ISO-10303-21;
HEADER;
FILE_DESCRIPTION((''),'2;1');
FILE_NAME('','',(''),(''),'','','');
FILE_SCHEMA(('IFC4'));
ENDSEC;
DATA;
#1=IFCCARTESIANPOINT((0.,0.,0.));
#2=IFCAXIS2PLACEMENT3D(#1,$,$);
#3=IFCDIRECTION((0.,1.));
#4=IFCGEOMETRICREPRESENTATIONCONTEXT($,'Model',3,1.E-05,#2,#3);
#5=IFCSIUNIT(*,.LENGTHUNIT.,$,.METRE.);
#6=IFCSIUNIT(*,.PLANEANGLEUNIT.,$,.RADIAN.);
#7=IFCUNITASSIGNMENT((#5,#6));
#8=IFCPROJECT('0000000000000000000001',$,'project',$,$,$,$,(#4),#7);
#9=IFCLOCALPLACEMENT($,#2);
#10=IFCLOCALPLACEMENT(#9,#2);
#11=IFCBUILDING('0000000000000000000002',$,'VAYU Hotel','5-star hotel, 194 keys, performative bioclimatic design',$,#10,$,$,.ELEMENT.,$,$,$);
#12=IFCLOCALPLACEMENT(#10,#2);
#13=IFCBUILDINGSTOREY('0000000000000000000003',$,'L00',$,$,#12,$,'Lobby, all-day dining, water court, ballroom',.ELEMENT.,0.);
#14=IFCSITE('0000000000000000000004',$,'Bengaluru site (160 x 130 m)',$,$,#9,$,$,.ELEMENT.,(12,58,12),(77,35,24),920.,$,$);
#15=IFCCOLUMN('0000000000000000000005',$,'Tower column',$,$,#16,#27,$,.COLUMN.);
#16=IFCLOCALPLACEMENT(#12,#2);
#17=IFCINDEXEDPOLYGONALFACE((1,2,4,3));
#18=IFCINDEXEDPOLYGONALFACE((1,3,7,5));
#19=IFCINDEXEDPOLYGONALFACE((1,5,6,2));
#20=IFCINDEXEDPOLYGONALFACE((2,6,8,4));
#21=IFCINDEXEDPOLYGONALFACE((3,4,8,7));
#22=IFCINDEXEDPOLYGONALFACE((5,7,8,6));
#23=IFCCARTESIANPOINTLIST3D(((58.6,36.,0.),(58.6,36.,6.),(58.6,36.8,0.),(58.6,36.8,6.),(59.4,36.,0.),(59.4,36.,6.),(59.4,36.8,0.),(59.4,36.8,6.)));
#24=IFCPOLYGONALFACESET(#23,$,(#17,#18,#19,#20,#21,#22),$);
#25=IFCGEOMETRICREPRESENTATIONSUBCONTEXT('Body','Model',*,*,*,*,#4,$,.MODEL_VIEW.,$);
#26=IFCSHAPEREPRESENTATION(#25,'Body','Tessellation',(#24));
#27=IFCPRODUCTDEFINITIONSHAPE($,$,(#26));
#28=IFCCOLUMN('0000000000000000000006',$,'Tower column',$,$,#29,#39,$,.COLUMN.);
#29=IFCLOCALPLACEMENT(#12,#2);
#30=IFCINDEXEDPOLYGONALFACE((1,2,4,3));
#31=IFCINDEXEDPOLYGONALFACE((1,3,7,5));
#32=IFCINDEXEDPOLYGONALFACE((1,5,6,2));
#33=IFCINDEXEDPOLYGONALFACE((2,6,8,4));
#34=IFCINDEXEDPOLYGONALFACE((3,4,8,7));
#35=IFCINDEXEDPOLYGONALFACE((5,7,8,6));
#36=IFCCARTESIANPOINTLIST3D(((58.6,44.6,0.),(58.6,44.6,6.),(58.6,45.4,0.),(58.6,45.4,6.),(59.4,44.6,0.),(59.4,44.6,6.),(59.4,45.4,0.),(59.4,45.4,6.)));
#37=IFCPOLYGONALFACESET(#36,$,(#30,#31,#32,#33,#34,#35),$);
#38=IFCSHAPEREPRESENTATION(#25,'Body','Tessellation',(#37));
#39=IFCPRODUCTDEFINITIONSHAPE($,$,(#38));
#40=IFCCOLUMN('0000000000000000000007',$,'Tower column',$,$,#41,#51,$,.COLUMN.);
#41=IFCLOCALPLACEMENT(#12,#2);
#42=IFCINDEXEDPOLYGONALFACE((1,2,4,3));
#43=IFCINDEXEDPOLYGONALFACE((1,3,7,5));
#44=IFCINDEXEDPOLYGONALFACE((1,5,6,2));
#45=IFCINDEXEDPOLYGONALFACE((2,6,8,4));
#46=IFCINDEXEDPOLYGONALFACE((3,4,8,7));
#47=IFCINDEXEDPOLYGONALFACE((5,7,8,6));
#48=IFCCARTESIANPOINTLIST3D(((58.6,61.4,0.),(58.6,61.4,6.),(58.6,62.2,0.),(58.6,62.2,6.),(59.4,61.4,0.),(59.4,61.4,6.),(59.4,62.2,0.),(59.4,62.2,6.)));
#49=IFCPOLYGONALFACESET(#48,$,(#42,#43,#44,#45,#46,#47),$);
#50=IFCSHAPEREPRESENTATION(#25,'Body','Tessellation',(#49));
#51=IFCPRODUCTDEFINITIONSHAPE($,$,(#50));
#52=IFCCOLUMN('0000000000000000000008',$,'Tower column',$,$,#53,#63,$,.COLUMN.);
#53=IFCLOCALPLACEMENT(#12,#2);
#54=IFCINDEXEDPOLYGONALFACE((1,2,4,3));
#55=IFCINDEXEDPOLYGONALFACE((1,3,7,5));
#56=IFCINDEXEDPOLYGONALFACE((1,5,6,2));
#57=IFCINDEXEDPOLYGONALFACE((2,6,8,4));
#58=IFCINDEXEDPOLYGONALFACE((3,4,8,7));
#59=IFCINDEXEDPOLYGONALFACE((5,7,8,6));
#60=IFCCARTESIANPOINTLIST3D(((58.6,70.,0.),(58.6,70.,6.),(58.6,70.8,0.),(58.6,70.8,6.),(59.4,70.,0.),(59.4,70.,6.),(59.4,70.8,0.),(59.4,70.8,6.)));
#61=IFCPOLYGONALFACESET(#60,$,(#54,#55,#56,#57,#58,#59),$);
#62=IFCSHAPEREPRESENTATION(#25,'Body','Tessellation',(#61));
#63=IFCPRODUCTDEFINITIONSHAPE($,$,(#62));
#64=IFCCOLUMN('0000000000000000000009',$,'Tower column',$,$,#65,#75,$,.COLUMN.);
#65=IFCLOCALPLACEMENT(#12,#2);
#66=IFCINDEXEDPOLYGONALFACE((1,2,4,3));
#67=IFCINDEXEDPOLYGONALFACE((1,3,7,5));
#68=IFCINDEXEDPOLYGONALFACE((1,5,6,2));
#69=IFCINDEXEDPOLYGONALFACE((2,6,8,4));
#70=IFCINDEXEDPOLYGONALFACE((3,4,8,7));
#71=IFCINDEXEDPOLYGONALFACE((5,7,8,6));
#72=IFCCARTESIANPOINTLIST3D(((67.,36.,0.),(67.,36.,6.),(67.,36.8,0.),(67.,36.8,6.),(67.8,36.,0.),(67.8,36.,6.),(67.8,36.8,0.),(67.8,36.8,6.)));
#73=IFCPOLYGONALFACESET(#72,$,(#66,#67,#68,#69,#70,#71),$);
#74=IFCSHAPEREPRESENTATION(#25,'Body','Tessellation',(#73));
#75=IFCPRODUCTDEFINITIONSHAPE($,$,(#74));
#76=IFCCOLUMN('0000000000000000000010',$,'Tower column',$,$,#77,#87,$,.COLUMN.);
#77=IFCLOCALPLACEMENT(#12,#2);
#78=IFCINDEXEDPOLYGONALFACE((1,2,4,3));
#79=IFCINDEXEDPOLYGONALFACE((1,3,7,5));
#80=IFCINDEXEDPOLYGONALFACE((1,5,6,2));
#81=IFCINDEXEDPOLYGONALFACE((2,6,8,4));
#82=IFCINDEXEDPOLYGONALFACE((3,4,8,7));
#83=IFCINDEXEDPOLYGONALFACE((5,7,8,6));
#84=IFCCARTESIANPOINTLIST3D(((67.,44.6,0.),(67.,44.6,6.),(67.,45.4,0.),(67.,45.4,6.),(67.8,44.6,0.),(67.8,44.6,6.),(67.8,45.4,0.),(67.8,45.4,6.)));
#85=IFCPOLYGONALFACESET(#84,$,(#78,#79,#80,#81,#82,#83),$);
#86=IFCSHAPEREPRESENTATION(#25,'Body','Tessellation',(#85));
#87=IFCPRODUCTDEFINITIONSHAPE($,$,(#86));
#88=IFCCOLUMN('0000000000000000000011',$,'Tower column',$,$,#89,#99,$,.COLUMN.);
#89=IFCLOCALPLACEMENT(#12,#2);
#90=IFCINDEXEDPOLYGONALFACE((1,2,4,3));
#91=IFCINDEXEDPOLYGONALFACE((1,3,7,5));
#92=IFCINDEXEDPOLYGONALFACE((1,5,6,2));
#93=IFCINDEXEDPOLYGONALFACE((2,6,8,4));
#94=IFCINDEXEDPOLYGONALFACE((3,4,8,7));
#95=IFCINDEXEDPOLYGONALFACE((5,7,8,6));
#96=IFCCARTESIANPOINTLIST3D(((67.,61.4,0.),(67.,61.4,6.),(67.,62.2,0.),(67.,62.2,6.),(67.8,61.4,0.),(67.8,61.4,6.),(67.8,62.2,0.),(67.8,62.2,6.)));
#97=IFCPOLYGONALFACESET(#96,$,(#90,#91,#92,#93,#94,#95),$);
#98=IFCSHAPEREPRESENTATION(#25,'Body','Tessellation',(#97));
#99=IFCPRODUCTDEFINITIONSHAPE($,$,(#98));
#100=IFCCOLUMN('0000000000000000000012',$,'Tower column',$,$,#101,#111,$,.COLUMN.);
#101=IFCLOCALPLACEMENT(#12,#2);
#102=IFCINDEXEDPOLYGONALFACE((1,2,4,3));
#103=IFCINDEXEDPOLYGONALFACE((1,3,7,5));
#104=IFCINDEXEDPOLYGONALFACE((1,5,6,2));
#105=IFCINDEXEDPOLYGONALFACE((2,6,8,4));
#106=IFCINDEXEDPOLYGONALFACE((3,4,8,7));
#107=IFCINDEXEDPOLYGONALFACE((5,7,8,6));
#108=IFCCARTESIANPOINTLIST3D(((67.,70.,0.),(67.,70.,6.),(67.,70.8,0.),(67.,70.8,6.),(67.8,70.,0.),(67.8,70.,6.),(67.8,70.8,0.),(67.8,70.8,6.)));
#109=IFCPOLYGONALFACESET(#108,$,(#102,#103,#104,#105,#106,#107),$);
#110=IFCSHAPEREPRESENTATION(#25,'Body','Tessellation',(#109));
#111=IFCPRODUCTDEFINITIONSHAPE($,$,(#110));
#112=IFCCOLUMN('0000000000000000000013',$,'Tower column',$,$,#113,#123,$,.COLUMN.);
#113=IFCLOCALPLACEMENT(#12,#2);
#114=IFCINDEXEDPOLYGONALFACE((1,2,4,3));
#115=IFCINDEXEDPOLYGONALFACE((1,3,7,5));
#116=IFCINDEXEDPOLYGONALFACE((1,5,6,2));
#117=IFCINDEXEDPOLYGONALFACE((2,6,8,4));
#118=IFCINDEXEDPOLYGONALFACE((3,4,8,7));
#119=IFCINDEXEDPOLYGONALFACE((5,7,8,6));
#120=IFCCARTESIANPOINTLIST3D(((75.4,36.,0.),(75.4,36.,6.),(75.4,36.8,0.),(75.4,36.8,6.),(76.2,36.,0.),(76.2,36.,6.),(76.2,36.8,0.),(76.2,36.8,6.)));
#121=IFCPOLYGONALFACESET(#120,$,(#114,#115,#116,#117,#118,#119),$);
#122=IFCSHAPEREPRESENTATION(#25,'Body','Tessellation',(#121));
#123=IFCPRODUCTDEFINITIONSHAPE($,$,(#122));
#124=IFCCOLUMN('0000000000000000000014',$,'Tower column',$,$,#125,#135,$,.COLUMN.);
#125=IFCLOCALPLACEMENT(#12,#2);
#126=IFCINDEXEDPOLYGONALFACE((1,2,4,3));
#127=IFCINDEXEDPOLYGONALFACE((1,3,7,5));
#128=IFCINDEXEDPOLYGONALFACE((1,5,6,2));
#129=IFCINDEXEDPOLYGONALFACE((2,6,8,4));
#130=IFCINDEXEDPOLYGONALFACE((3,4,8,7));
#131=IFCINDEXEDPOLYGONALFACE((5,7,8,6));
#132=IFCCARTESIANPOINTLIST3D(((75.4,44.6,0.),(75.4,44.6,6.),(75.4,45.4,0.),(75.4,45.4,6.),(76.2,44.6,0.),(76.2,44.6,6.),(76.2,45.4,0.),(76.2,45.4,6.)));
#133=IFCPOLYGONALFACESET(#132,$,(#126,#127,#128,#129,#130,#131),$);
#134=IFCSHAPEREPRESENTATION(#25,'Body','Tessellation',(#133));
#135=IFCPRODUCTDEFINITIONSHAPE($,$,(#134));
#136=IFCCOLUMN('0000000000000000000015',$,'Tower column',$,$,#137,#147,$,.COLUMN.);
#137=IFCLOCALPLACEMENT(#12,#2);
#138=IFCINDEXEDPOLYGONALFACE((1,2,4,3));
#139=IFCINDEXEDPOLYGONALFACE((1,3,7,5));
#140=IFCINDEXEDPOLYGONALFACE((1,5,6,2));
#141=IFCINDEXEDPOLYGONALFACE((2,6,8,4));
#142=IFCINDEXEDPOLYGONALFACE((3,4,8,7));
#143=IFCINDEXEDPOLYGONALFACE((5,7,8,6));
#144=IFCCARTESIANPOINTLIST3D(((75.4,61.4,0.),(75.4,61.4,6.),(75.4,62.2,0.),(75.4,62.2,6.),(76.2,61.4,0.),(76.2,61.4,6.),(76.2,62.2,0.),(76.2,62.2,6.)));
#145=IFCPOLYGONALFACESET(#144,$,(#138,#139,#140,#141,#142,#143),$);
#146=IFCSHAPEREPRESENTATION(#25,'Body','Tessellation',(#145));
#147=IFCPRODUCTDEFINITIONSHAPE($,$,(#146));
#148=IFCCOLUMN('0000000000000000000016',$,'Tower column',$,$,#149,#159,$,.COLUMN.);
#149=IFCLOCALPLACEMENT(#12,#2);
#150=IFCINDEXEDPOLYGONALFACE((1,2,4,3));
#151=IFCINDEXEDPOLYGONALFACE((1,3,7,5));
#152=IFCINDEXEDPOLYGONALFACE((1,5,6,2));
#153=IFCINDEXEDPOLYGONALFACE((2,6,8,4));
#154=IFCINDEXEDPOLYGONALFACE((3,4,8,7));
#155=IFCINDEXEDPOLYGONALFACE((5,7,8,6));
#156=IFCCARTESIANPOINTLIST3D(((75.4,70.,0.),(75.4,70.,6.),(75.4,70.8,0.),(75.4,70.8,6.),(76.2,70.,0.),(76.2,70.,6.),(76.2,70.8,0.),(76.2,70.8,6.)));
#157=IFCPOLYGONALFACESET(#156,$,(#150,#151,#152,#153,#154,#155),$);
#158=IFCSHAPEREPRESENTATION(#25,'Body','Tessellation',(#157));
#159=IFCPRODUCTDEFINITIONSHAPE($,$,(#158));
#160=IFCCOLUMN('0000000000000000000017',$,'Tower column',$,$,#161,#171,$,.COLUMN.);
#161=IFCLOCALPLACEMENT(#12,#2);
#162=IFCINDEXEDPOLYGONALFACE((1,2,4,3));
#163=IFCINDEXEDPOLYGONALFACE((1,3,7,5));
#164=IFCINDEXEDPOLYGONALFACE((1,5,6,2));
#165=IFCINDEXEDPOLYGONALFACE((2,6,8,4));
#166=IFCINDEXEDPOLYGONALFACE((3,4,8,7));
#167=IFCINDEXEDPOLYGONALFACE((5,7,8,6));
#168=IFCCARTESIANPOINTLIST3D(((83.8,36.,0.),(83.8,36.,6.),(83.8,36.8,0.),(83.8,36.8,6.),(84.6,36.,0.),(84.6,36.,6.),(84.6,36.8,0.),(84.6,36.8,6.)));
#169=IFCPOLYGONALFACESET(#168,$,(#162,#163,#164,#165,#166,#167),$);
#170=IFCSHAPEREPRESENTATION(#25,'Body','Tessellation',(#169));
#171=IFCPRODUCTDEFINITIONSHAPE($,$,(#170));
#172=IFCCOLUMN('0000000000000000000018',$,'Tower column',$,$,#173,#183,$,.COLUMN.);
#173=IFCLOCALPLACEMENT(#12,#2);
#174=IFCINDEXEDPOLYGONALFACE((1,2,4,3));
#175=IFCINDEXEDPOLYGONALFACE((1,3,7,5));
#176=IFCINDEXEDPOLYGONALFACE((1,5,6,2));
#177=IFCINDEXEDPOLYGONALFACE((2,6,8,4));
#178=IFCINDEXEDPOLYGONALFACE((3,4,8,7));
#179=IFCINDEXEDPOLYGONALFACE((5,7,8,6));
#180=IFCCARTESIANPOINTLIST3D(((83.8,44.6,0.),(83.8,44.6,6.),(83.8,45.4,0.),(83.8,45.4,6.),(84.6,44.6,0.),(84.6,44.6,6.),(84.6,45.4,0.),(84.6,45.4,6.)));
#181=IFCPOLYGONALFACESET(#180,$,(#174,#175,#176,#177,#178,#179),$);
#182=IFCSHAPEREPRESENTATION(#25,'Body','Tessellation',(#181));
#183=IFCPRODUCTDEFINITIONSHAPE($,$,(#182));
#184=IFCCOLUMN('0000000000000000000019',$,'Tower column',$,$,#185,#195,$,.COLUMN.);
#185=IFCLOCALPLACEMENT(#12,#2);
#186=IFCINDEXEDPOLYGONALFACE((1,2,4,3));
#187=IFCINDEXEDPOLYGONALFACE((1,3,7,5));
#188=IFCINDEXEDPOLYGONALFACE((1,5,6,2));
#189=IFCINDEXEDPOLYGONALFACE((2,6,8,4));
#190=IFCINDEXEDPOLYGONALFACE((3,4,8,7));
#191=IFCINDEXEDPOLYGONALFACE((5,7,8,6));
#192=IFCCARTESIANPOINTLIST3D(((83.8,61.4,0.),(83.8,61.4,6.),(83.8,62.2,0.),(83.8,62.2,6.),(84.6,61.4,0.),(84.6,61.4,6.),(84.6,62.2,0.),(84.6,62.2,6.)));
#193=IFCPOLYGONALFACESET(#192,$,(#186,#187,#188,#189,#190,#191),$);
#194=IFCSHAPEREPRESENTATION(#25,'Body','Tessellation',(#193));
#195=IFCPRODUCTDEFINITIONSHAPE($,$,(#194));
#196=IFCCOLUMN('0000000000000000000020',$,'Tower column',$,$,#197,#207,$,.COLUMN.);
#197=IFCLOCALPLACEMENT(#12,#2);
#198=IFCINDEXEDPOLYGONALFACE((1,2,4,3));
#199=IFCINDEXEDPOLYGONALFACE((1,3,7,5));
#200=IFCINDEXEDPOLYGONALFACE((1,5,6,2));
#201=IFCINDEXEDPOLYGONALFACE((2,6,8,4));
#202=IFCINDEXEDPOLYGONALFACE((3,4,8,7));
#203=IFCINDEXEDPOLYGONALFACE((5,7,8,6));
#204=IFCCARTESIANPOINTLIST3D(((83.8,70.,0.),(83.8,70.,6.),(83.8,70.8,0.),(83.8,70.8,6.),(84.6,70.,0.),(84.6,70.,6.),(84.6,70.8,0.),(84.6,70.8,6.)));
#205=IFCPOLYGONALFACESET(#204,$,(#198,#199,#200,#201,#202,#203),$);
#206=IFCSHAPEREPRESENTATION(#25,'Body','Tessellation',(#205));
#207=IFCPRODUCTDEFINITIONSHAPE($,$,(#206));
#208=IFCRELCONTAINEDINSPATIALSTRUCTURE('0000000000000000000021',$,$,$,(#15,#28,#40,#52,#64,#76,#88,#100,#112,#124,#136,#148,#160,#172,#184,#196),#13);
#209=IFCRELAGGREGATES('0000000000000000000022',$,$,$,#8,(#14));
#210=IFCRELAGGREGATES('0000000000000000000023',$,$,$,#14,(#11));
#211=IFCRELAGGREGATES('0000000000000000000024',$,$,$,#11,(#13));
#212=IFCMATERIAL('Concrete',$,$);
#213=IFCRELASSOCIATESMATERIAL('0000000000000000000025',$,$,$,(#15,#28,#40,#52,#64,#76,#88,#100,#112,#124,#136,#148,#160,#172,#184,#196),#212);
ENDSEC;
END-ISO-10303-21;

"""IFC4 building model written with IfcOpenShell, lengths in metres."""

from ifc_helpers import new_model, si_unit, direction, origin, place, context, subcontext, project, spatial, polyline, outline, extrude, material, element, save


model = new_model("IFC4")

# Units and contexts
model_context = context("Model", 3, precision=1e-05, world=origin(), true_north=direction((0.0, 1.0)))
body_context = subcontext(model_context, "Body", "Model", "MODEL_VIEW")
ifc_project = project(units=[si_unit("LENGTHUNIT", "METRE"), si_unit("PLANEANGLEUNIT", "RADIAN")], contexts=[model_context])

# Site, building, storey
site_placement = place(None, origin())
site = spatial("IfcSite", under=ifc_project, at=site_placement, Name="Bengaluru site (160 x 130 m)", CompositionType="ELEMENT", RefLatitude=(12, 58, 12), RefLongitude=(77, 35, 24), RefElevation=920.0)
building_placement = place(site_placement, origin())
building = spatial("IfcBuilding", under=site, at=building_placement, Name="VAYU Hotel", Description="5-star hotel, 194 keys, performative bioclimatic design", CompositionType="ELEMENT")
storey_placement = place(building_placement, origin())
storey = spatial("IfcBuildingStorey", under=building, at=storey_placement, Name="L00", LongName="Lobby, all-day dining, water court, ballroom", CompositionType="ELEMENT", Elevation=0.0)

# Columns
ifc_material_1 = material(Name="Concrete")
column_1_placement = place(storey_placement, origin())
element("IfcColumn", 1, at=column_1_placement, inside=storey, material=ifc_material_1, Name="Tower column", PredefinedType="COLUMN", context=body_context, shape_type="SweptSolid", body=[
    extrude(outline(polyline([(58.6, 36.0), (59.4, 36.0), (59.4, 36.8), (58.6, 36.8), (58.6, 36.0)])), origin(), (0.0, 0.0, 1.0), 6.0),
])
column_2_placement = place(storey_placement, origin())
element("IfcColumn", 2, at=column_2_placement, inside=storey, material=ifc_material_1, Name="Tower column", PredefinedType="COLUMN", context=body_context, shape_type="SweptSolid", body=[
    extrude(outline(polyline([(58.6, 44.6), (59.4, 44.6), (59.4, 45.4), (58.6, 45.4), (58.6, 44.6)])), origin(), (0.0, 0.0, 1.0), 6.0),
])
column_3_placement = place(storey_placement, origin())
element("IfcColumn", 3, at=column_3_placement, inside=storey, material=ifc_material_1, Name="Tower column", PredefinedType="COLUMN", context=body_context, shape_type="SweptSolid", body=[
    extrude(outline(polyline([(58.6, 61.4), (59.4, 61.4), (59.4, 62.2), (58.6, 62.2), (58.6, 61.4)])), origin(), (0.0, 0.0, 1.0), 6.0),
])
column_4_placement = place(storey_placement, origin())
element("IfcColumn", 4, at=column_4_placement, inside=storey, material=ifc_material_1, Name="Tower column", PredefinedType="COLUMN", context=body_context, shape_type="SweptSolid", body=[
    extrude(outline(polyline([(58.6, 70.0), (59.4, 70.0), (59.4, 70.8), (58.6, 70.8), (58.6, 70.0)])), origin(), (0.0, 0.0, 1.0), 6.0),
])
column_5_placement = place(storey_placement, origin())
element("IfcColumn", 5, at=column_5_placement, inside=storey, material=ifc_material_1, Name="Tower column", PredefinedType="COLUMN", context=body_context, shape_type="SweptSolid", body=[
    extrude(outline(polyline([(67.0, 36.0), (67.8, 36.0), (67.8, 36.8), (67.0, 36.8), (67.0, 36.0)])), origin(), (0.0, 0.0, 1.0), 6.0),
])
column_6_placement = place(storey_placement, origin())
element("IfcColumn", 6, at=column_6_placement, inside=storey, material=ifc_material_1, Name="Tower column", PredefinedType="COLUMN", context=body_context, shape_type="SweptSolid", body=[
    extrude(outline(polyline([(67.0, 44.6), (67.8, 44.6), (67.8, 45.4), (67.0, 45.4), (67.0, 44.6)])), origin(), (0.0, 0.0, 1.0), 6.0),
])
column_7_placement = place(storey_placement, origin())
element("IfcColumn", 7, at=column_7_placement, inside=storey, material=ifc_material_1, Name="Tower column", PredefinedType="COLUMN", context=body_context, shape_type="SweptSolid", body=[
    extrude(outline(polyline([(67.0, 61.4), (67.8, 61.4), (67.8, 62.2), (67.0, 62.2), (67.0, 61.4)])), origin(), (0.0, 0.0, 1.0), 6.0),
])
column_8_placement = place(storey_placement, origin())
element("IfcColumn", 8, at=column_8_placement, inside=storey, material=ifc_material_1, Name="Tower column", PredefinedType="COLUMN", context=body_context, shape_type="SweptSolid", body=[
    extrude(outline(polyline([(67.0, 70.0), (67.8, 70.0), (67.8, 70.8), (67.0, 70.8), (67.0, 70.0)])), origin(), (0.0, 0.0, 1.0), 6.0),
])
column_9_placement = place(storey_placement, origin())
element("IfcColumn", 9, at=column_9_placement, inside=storey, material=ifc_material_1, Name="Tower column", PredefinedType="COLUMN", context=body_context, shape_type="SweptSolid", body=[
    extrude(outline(polyline([(75.4, 36.0), (76.2, 36.0), (76.2, 36.8), (75.4, 36.8), (75.4, 36.0)])), origin(), (0.0, 0.0, 1.0), 6.0),
])
column_10_placement = place(storey_placement, origin())
element("IfcColumn", 10, at=column_10_placement, inside=storey, material=ifc_material_1, Name="Tower column", PredefinedType="COLUMN", context=body_context, shape_type="SweptSolid", body=[
    extrude(outline(polyline([(75.4, 44.6), (76.2, 44.6), (76.2, 45.4), (75.4, 45.4), (75.4, 44.6)])), origin(), (0.0, 0.0, 1.0), 6.0),
])
column_11_placement = place(storey_placement, origin())
element("IfcColumn", 11, at=column_11_placement, inside=storey, material=ifc_material_1, Name="Tower column", PredefinedType="COLUMN", context=body_context, shape_type="SweptSolid", body=[
    extrude(outline(polyline([(75.4, 61.4), (76.2, 61.4), (76.2, 62.2), (75.4, 62.2), (75.4, 61.4)])), origin(), (0.0, 0.0, 1.0), 6.0),
])
column_12_placement = place(storey_placement, origin())
element("IfcColumn", 12, at=column_12_placement, inside=storey, material=ifc_material_1, Name="Tower column", PredefinedType="COLUMN", context=body_context, shape_type="SweptSolid", body=[
    extrude(outline(polyline([(75.4, 70.0), (76.2, 70.0), (76.2, 70.8), (75.4, 70.8), (75.4, 70.0)])), origin(), (0.0, 0.0, 1.0), 6.0),
])
column_13_placement = place(storey_placement, origin())
element("IfcColumn", 13, at=column_13_placement, inside=storey, material=ifc_material_1, Name="Tower column", PredefinedType="COLUMN", context=body_context, shape_type="SweptSolid", body=[
    extrude(outline(polyline([(83.8, 36.0), (84.6, 36.0), (84.6, 36.8), (83.8, 36.8), (83.8, 36.0)])), origin(), (0.0, 0.0, 1.0), 6.0),
])
column_14_placement = place(storey_placement, origin())
element("IfcColumn", 14, at=column_14_placement, inside=storey, material=ifc_material_1, Name="Tower column", PredefinedType="COLUMN", context=body_context, shape_type="SweptSolid", body=[
    extrude(outline(polyline([(83.8, 44.6), (84.6, 44.6), (84.6, 45.4), (83.8, 45.4), (83.8, 44.6)])), origin(), (0.0, 0.0, 1.0), 6.0),
])
column_15_placement = place(storey_placement, origin())
element("IfcColumn", 15, at=column_15_placement, inside=storey, material=ifc_material_1, Name="Tower column", PredefinedType="COLUMN", context=body_context, shape_type="SweptSolid", body=[
    extrude(outline(polyline([(83.8, 61.4), (84.6, 61.4), (84.6, 62.2), (83.8, 62.2), (83.8, 61.4)])), origin(), (0.0, 0.0, 1.0), 6.0),
])
column_16_placement = place(storey_placement, origin())
element("IfcColumn", 16, at=column_16_placement, inside=storey, material=ifc_material_1, Name="Tower column", PredefinedType="COLUMN", context=body_context, shape_type="SweptSolid", body=[
    extrude(outline(polyline([(83.8, 70.0), (84.6, 70.0), (84.6, 70.8), (83.8, 70.8), (83.8, 70.0)])), origin(), (0.0, 0.0, 1.0), 6.0),
])

save(model, "model.ifc")
